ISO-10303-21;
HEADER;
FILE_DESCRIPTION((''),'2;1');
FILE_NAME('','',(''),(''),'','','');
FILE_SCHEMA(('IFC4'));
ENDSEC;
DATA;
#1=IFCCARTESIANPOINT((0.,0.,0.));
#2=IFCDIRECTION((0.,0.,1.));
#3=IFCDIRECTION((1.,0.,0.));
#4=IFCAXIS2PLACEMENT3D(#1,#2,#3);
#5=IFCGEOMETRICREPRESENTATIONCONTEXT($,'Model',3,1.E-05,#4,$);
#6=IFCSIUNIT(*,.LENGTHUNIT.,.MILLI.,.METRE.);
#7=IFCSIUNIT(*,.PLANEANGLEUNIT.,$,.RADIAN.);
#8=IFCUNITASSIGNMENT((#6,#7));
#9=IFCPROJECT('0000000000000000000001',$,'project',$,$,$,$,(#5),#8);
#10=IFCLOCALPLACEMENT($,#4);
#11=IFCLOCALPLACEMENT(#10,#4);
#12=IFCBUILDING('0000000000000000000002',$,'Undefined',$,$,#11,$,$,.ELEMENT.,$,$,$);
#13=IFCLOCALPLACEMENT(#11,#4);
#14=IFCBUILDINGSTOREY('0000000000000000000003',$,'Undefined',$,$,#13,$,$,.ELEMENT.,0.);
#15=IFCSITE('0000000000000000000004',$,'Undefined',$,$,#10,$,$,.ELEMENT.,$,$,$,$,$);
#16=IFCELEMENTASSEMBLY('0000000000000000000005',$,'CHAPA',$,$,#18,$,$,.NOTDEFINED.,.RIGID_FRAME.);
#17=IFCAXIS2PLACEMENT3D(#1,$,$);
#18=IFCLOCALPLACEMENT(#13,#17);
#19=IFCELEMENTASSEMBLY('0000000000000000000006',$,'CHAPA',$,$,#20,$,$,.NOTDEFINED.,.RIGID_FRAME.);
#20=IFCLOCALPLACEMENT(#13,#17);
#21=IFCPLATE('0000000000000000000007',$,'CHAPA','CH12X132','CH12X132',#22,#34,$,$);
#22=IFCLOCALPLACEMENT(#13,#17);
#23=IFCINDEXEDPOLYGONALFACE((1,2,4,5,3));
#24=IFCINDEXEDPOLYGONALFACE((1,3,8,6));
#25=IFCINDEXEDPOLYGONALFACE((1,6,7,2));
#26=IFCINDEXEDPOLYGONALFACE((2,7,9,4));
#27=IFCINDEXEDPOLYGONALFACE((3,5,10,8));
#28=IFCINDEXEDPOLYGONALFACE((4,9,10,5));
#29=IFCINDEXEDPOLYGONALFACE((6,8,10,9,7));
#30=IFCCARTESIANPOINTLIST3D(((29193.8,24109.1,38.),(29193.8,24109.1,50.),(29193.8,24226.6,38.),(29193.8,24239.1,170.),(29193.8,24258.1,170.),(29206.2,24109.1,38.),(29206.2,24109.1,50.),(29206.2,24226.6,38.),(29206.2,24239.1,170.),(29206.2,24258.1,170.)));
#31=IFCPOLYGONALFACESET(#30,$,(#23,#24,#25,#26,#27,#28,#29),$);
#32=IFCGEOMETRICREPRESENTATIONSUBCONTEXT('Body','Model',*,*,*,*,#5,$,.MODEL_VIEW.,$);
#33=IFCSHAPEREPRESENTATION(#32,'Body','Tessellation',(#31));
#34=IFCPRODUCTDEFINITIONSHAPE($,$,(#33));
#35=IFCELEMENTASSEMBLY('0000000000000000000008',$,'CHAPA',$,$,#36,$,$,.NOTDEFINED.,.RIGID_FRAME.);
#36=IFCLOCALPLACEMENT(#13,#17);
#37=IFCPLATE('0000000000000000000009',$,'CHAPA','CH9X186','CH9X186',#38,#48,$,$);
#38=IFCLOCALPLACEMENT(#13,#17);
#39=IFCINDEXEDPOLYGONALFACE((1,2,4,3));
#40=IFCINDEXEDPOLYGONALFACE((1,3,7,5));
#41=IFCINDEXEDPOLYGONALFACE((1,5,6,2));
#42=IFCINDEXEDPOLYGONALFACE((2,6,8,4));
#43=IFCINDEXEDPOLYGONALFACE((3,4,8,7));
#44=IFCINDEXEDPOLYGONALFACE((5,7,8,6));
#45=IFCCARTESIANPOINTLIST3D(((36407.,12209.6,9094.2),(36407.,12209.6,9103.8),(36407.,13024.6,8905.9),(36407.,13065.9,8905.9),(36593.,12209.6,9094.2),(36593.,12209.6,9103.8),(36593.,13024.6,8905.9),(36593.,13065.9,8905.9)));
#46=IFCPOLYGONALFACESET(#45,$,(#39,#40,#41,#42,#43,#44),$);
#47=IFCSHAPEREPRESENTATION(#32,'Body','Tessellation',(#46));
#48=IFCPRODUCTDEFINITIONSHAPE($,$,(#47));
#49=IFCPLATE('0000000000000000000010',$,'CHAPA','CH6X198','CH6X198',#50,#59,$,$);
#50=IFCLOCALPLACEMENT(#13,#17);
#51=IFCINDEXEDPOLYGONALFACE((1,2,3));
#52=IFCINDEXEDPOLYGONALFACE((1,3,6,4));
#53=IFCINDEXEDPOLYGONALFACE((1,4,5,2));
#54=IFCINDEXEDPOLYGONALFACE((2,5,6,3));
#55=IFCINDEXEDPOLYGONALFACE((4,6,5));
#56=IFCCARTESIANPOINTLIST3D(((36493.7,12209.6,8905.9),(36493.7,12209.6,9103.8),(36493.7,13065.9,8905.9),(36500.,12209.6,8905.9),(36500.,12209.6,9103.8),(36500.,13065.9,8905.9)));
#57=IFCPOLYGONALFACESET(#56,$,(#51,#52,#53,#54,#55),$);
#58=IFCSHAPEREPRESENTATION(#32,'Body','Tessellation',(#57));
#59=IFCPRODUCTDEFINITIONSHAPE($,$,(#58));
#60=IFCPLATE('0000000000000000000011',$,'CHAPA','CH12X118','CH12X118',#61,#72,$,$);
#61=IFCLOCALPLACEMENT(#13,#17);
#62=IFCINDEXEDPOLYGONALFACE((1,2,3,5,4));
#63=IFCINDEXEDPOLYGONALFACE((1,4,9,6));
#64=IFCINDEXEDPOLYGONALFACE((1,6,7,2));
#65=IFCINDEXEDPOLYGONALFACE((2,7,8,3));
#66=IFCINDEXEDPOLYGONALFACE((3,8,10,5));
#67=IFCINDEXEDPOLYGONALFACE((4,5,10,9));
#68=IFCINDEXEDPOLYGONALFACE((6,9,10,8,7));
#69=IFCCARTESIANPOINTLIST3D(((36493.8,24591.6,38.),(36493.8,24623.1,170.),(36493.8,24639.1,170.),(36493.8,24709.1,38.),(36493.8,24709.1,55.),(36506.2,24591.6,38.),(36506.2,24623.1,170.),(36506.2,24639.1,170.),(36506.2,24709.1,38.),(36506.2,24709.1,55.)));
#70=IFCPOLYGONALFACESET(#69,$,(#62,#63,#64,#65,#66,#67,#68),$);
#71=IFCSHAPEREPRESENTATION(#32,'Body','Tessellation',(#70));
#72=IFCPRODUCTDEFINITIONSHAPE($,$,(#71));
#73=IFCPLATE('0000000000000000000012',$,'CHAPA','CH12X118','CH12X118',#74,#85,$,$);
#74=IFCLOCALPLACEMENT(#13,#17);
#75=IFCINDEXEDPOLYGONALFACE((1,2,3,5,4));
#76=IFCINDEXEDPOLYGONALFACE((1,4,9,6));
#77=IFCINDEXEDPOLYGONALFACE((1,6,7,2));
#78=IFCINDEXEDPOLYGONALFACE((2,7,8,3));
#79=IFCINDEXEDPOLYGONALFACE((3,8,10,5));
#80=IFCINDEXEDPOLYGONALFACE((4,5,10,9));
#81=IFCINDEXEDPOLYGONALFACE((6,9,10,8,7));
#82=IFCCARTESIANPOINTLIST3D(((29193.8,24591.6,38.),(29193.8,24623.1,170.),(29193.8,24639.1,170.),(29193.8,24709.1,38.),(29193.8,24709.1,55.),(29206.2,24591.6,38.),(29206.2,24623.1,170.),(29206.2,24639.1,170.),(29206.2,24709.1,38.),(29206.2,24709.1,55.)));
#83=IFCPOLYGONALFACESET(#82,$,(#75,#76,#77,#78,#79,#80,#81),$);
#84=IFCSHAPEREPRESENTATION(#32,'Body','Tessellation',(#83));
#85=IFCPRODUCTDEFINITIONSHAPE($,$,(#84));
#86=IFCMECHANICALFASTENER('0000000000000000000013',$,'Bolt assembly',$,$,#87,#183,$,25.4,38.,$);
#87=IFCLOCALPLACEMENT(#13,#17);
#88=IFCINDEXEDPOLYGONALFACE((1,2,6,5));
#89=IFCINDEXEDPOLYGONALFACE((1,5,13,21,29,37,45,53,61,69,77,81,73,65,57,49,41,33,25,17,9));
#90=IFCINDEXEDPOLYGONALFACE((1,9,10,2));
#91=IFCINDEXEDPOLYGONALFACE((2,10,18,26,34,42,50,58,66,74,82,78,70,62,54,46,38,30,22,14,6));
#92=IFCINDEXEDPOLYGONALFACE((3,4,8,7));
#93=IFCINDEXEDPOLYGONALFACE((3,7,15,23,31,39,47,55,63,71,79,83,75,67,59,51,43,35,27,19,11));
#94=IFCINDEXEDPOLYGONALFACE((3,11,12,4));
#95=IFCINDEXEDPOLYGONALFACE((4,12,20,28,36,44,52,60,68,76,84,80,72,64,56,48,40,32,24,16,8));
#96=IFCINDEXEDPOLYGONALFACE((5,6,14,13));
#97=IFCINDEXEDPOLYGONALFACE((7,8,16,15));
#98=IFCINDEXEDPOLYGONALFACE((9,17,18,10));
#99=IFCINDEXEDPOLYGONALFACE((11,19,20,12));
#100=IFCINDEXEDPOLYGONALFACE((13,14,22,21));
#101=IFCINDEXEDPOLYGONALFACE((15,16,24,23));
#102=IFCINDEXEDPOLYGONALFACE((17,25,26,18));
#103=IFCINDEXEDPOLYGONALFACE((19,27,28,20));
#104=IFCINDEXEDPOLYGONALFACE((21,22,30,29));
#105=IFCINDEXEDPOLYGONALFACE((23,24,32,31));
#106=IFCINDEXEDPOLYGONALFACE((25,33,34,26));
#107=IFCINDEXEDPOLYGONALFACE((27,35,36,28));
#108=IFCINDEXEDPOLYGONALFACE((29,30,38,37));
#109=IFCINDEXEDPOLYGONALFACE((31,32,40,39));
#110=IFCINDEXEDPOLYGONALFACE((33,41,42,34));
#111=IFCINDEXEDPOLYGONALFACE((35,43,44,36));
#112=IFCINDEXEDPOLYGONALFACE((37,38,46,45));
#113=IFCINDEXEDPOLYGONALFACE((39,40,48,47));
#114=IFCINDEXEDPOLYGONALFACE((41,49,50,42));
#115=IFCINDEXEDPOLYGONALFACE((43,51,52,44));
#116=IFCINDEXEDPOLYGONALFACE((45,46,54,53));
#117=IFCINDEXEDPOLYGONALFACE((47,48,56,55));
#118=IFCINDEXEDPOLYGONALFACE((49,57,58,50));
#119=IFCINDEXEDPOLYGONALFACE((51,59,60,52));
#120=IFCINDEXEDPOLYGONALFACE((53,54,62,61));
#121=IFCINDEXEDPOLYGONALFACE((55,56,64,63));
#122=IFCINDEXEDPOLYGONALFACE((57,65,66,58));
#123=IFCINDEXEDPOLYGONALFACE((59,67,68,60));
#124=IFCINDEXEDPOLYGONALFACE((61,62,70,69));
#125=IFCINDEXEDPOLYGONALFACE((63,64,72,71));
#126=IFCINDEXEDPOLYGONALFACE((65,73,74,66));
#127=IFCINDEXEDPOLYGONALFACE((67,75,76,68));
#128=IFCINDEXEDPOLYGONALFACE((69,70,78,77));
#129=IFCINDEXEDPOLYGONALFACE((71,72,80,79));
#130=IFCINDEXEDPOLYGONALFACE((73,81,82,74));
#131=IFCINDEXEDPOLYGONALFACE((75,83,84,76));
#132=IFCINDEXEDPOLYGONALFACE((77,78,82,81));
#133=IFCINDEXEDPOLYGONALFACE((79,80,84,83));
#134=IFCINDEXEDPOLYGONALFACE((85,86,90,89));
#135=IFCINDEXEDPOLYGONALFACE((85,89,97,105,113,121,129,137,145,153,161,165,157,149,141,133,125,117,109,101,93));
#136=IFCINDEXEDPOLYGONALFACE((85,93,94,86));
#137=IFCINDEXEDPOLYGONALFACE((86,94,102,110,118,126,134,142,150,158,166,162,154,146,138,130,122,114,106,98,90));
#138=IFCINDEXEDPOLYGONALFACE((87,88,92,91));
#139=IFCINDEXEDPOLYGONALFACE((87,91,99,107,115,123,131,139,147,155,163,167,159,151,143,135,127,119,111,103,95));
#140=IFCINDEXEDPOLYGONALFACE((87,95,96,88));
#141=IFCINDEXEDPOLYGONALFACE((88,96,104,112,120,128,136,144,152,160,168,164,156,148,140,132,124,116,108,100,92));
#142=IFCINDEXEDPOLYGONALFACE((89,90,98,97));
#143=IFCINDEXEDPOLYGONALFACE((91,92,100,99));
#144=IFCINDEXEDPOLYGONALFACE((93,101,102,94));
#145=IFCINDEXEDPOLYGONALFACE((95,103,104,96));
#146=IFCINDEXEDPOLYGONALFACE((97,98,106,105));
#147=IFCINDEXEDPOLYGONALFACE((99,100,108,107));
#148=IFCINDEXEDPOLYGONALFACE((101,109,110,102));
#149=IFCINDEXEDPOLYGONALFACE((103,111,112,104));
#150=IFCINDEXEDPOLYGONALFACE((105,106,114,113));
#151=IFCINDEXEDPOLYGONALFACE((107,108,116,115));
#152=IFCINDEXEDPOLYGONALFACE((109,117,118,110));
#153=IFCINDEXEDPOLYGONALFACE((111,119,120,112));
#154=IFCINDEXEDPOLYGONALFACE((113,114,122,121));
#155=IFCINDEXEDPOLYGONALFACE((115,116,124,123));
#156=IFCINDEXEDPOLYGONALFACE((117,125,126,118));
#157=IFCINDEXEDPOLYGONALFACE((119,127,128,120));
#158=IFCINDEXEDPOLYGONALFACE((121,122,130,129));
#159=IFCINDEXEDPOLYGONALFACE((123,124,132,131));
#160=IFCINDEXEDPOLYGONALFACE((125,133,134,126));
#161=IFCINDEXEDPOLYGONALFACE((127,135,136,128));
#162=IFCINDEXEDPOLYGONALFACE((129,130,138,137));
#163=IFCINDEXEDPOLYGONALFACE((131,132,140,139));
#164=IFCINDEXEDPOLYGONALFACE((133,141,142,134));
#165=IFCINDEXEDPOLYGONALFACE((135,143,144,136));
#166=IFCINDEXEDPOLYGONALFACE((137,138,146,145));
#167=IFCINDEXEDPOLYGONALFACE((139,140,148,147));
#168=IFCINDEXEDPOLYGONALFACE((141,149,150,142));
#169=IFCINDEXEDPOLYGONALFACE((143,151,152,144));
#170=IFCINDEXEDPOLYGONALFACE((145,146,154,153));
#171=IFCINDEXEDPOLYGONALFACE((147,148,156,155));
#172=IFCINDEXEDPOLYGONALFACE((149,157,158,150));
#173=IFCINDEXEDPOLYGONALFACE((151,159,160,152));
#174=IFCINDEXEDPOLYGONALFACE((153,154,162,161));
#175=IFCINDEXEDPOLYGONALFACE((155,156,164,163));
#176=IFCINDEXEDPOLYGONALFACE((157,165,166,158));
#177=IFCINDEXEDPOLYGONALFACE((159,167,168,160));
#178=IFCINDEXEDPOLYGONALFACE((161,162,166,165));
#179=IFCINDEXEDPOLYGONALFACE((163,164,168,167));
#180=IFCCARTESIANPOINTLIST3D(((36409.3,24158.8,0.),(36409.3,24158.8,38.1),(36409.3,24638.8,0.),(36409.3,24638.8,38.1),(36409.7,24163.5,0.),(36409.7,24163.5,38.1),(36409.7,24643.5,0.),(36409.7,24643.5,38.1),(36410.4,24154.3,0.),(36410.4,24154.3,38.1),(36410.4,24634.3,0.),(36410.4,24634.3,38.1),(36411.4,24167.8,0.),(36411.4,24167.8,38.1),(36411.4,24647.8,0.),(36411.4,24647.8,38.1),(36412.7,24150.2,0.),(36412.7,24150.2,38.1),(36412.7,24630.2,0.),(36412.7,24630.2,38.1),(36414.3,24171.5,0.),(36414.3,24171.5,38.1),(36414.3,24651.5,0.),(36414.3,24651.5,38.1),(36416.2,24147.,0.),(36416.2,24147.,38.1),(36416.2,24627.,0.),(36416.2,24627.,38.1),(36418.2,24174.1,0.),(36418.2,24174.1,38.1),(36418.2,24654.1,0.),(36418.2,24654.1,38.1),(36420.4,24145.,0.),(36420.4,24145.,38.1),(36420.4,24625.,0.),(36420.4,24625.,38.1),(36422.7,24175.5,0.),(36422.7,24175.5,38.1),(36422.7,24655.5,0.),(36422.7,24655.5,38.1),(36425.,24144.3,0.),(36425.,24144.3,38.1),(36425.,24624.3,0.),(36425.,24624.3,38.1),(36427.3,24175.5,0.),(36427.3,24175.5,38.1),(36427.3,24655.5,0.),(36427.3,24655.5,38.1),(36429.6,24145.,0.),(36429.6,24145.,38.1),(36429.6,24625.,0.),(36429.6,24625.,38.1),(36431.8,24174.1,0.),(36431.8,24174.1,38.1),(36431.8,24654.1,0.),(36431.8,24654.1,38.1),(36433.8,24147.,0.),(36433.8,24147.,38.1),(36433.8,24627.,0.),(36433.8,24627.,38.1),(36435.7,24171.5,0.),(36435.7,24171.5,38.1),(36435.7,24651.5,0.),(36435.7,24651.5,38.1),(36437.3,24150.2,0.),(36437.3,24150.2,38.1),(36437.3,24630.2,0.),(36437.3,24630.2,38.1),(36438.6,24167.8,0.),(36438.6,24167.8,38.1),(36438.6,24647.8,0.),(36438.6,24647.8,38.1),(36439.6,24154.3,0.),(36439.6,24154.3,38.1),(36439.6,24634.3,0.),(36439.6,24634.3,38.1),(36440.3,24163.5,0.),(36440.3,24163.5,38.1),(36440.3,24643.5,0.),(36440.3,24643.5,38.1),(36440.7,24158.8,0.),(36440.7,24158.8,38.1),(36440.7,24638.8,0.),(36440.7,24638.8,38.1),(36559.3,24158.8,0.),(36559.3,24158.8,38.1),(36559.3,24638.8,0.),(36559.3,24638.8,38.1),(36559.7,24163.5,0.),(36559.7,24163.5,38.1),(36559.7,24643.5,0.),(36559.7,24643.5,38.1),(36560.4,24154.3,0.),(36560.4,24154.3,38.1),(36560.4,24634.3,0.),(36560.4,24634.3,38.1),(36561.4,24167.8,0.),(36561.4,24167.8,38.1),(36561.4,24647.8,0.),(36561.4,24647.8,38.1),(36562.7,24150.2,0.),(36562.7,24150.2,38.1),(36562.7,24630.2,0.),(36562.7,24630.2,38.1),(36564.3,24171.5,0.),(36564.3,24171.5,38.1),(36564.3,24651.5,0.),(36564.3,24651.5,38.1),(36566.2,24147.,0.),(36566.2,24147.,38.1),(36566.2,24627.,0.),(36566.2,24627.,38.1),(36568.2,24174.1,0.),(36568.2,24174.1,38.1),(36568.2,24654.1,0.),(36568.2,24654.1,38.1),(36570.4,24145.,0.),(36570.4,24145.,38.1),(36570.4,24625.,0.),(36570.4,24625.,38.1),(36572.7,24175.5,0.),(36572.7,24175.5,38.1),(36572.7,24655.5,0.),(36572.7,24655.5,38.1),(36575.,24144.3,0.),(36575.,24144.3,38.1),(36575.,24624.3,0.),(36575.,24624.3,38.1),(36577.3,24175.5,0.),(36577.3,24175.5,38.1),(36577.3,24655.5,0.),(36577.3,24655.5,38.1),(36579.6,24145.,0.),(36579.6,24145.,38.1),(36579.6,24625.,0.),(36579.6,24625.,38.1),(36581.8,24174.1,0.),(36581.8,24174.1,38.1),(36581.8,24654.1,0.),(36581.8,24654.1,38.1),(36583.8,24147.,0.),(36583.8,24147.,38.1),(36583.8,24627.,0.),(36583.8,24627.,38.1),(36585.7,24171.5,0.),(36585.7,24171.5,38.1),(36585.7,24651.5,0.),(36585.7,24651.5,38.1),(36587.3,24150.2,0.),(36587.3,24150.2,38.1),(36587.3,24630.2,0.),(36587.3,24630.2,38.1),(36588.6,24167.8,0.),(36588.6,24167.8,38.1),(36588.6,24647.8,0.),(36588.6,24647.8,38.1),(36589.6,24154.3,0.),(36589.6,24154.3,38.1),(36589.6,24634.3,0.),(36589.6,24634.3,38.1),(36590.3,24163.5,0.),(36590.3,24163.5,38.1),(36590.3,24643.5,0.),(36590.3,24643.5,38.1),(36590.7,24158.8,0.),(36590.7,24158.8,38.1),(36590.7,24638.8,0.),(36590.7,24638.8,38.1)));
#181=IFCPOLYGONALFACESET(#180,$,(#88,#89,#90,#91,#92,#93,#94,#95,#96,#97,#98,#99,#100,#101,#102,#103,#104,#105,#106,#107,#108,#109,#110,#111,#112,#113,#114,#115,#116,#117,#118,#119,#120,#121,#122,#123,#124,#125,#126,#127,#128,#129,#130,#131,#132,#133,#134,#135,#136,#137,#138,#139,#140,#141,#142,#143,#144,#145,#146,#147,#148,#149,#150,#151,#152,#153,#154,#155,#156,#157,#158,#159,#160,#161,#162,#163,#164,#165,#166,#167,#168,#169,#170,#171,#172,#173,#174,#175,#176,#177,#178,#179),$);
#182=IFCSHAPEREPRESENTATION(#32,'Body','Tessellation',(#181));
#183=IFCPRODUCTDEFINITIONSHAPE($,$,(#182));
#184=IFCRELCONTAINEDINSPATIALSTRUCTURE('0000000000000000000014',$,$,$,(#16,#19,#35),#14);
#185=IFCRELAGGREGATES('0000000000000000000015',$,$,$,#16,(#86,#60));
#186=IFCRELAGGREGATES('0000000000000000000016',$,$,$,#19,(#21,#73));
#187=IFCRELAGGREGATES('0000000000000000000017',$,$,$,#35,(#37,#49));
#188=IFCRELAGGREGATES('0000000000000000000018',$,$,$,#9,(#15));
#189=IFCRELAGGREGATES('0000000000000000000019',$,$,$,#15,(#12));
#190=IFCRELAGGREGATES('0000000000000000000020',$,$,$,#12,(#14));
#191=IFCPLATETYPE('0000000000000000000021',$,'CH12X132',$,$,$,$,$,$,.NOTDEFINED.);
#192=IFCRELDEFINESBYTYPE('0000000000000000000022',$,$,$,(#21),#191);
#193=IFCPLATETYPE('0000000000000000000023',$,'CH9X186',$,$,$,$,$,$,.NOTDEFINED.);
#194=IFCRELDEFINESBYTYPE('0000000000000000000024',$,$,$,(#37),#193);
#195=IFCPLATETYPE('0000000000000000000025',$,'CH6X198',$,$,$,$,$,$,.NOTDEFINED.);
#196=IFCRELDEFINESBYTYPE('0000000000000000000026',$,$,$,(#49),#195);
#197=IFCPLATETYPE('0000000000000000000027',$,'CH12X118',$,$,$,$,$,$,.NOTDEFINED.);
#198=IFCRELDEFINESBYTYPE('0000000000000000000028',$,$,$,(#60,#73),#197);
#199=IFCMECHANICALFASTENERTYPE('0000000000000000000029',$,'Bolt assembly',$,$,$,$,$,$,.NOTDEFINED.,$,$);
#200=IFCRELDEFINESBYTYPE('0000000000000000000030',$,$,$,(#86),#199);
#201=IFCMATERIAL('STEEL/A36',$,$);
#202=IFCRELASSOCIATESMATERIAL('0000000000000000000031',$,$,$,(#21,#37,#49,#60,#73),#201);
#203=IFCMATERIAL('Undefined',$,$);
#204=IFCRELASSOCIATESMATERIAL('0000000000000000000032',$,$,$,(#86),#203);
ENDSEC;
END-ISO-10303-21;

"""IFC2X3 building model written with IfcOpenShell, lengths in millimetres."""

from ifc_helpers import new_model, si_unit, frame, origin_with_axes, origin_2d_with_axis, place, context, subcontext, project, spatial, polyline, circle, outline, extrude, clip, halfspace, source, transform, mapped, material, type_object, element, aggregate, save


model = new_model("IFC2X3")

# Units and contexts
model_context = context("Model", 3, precision=1e-05, world=origin_with_axes())
body_context = subcontext(model_context, "Body", "Model", "MODEL_VIEW")
ifc_project = project(units=[si_unit("LENGTHUNIT", "METRE", prefix="MILLI"), si_unit("PLANEANGLEUNIT", "RADIAN")], contexts=[model_context])

# Site, building, storey
site_placement = place(None, origin_with_axes())
site = spatial("IfcSite", under=ifc_project, at=site_placement, Name="Undefined", CompositionType="ELEMENT")
building_placement = place(site_placement, origin_with_axes())
building = spatial("IfcBuilding", under=site, at=building_placement, Name="Undefined", CompositionType="ELEMENT")
storey_placement = place(building_placement, origin_with_axes())
storey = spatial("IfcBuildingStorey", under=building, at=storey_placement, Name="Undefined", CompositionType="ELEMENT", Elevation=0.0)

# Element assemblies
assembly_1_placement = place(storey_placement, origin_with_axes())
assembly_1 = element("IfcElementAssembly", 1, at=assembly_1_placement, inside=storey, Name="CHAPA", AssemblyPlace="NOTDEFINED", PredefinedType="RIGID_FRAME")
assembly_2_placement = place(storey_placement, origin_with_axes())
assembly_2 = element("IfcElementAssembly", 2, at=assembly_2_placement, inside=storey, Name="CHAPA", AssemblyPlace="NOTDEFINED", PredefinedType="RIGID_FRAME")

# Plate
ifc_material_1 = material(Name="STEEL/A36")
plate_type_1 = type_object("IfcPlateType", Name="CH12X132", PredefinedType="NOTDEFINED")
plate_1_placement = place(assembly_2_placement, frame((29200.0, 24226.6, 38.0), z_axis=(-1.0, 0.0, 0.0), x_axis=(0.0, -1.0, 0.0)))
plate_1 = element("IfcPlate", 3, at=plate_1_placement, type_object=plate_type_1, material=ifc_material_1, Name="CHAPA", Description="CH12X132", ObjectType="CH12X132", context=body_context, shape_type="SweptSolid", body=[
    extrude(outline(polyline([(0.0, 0.0), (117.5, 0.0), (117.5, 12.0), (-12.5, 132.0), (-31.6, 132.0), (0.0, 0.0)])), frame((0.0, 0.0, -6.2), z_axis=(0.0, 0.0, 1.0), x_axis=(1.0, 0.0, 0.0)), (0.0, 0.0, 1.0), 12.5),
])

# Element assembly, plates
assembly_3_placement = place(storey_placement, origin_with_axes())
assembly_3 = element("IfcElementAssembly", 4, at=assembly_3_placement, inside=storey, Name="CHAPA", AssemblyPlace="NOTDEFINED", PredefinedType="RIGID_FRAME")
plate_type_2 = type_object("IfcPlateType", Name="CH9X186", PredefinedType="NOTDEFINED")
plate_2_placement = place(assembly_3_placement, frame((36593.0, 12208.6, 9099.3), z_axis=(0.0, -0.225125, -0.97433), x_axis=(-1.0, 0.0, 0.0)))
plate_2 = element("IfcPlate", 5, at=plate_2_placement, type_object=plate_type_2, material=ifc_material_1, Name="CHAPA", Description="CH9X186", ObjectType="CH9X186", context=body_context, shape_type="Clipping", body=[
    clip(clip(extrude(outline(polyline([(0.0, 0.0), (186.0, 0.0), (186.0, 878.9), (0.0, 878.9), (0.0, 0.0)])), frame((0.0, 0.0, -4.7), z_axis=(0.0, 0.0, 1.0), x_axis=(1.0, 0.0, 0.0)), (0.0, 0.0, 1.0), 9.3), halfspace(frame((186.0, -500.0, 314.0), z_axis=(0.0, 0.225128, 0.974329), x_axis=(-1.0, 0.0, 0.0)), False)), halfspace(frame((0.0, 2.1, 4.7), z_axis=(0.0, -0.97433, 0.225125), x_axis=(1.0, 0.0, 0.0)), False)),
])
plate_type_3 = type_object("IfcPlateType", Name="CH6X198", PredefinedType="NOTDEFINED")
plate_3_placement = place(assembly_3_placement, frame((36496.8, 13065.9, 8905.9), z_axis=(-1.0, 0.0, 0.0), x_axis=(0.0, -1.0, 0.0)))
plate_3 = element("IfcPlate", 6, at=plate_3_placement, type_object=plate_type_3, material=ifc_material_1, Name="CHAPA", Description="CH6X198", ObjectType="CH6X198", context=body_context, shape_type="SweptSolid", body=[
    extrude(outline(polyline([(0.0, 0.0), (856.3, 0.0), (856.3, 197.9), (0.0, 0.0)])), frame((0.0, 0.0, -3.1), z_axis=(0.0, 0.0, 1.0), x_axis=(1.0, 0.0, 0.0)), (0.0, 0.0, 1.0), 6.3),
])

# Plates
plate_type_4 = type_object("IfcPlateType", Name="CH12X118", PredefinedType="NOTDEFINED")
plate_4_placement = place(assembly_1_placement, frame((36500.0, 24709.1, 38.0), z_axis=(-1.0, 0.0, 0.0), x_axis=(0.0, -1.0, 0.0)))
plate_4 = element("IfcPlate", 7, at=plate_4_placement, type_object=plate_type_4, material=ifc_material_1, Name="CHAPA", Description="CH12X118", ObjectType="CH12X118", context=body_context, shape_type="SweptSolid", body=[
    extrude(outline(polyline([(0.0, 0.0), (117.5, 0.0), (85.9, 132.0), (70.0, 132.0), (0.0, 17.0), (0.0, 0.0)])), frame((0.0, 0.0, -6.2), z_axis=(0.0, 0.0, 1.0), x_axis=(1.0, 0.0, 0.0)), (0.0, 0.0, 1.0), 12.5),
])
plate_5_placement = place(assembly_2_placement, frame((29200.0, 24709.1, 38.0), z_axis=(-1.0, 0.0, 0.0), x_axis=(0.0, -1.0, 0.0)))
plate_5 = element("IfcPlate", 8, at=plate_5_placement, type_object=plate_type_4, material=ifc_material_1, Name="CHAPA", Description="CH12X118", ObjectType="CH12X118", context=body_context, shape_type="SweptSolid", body=[
    extrude(outline(polyline([(0.0, 0.0), (117.5, 0.0), (85.9, 132.0), (70.0, 132.0), (0.0, 17.0), (0.0, 0.0)])), frame((0.0, 0.0, -6.2), z_axis=(0.0, 0.0, 1.0), x_axis=(1.0, 0.0, 0.0)), (0.0, 0.0, 1.0), 12.5),
])

# Shared definitions
ifc_material_2 = material(Name="Undefined")
mechanical_fastener_type = type_object("IfcMechanicalFastenerType", Name="Bolt assembly")

# Mechanical fastener
shared_shape_1 = source(origin_with_axes(), body_context, "Body", "SweptSolid", [
    extrude(circle(Radius=15.7, at=origin_2d_with_axis()), frame((0.0, -38.0, 0.0), z_axis=(0.0, 1.0, 0.0), x_axis=(1.0, 0.0, 0.0)), (0.0, 0.0, 1.0), 38.1),
])
mechanical_fastener_1_placement = place(assembly_1_placement, frame((36500.0, 24640.0, 38.0), z_axis=(-1.0, 0.0, 0.0), x_axis=(0.0, -1.0, 0.0)))
mechanical_fastener_1 = element("IfcMechanicalFastener", 9, at=mechanical_fastener_1_placement, type_object=mechanical_fastener_type, material=ifc_material_2, Name="Bolt assembly", NominalDiameter=25.4, NominalLength=38.0, context=body_context, shape_type="MappedRepresentation", body=[
    mapped(shared_shape_1, transform((0.0, 0.0, -75.0))),
    mapped(shared_shape_1, transform((0.0, 0.0, 75.0))),
    mapped(shared_shape_1, transform((480.0, 0.0, -75.0))),
    mapped(shared_shape_1, transform((480.0, 0.0, 75.0))),
])
aggregate(assembly_1, [mechanical_fastener_1, plate_4])
aggregate(assembly_2, [plate_1, plate_5])
aggregate(assembly_3, [plate_2, plate_3])

save(model, "model.ifc")
